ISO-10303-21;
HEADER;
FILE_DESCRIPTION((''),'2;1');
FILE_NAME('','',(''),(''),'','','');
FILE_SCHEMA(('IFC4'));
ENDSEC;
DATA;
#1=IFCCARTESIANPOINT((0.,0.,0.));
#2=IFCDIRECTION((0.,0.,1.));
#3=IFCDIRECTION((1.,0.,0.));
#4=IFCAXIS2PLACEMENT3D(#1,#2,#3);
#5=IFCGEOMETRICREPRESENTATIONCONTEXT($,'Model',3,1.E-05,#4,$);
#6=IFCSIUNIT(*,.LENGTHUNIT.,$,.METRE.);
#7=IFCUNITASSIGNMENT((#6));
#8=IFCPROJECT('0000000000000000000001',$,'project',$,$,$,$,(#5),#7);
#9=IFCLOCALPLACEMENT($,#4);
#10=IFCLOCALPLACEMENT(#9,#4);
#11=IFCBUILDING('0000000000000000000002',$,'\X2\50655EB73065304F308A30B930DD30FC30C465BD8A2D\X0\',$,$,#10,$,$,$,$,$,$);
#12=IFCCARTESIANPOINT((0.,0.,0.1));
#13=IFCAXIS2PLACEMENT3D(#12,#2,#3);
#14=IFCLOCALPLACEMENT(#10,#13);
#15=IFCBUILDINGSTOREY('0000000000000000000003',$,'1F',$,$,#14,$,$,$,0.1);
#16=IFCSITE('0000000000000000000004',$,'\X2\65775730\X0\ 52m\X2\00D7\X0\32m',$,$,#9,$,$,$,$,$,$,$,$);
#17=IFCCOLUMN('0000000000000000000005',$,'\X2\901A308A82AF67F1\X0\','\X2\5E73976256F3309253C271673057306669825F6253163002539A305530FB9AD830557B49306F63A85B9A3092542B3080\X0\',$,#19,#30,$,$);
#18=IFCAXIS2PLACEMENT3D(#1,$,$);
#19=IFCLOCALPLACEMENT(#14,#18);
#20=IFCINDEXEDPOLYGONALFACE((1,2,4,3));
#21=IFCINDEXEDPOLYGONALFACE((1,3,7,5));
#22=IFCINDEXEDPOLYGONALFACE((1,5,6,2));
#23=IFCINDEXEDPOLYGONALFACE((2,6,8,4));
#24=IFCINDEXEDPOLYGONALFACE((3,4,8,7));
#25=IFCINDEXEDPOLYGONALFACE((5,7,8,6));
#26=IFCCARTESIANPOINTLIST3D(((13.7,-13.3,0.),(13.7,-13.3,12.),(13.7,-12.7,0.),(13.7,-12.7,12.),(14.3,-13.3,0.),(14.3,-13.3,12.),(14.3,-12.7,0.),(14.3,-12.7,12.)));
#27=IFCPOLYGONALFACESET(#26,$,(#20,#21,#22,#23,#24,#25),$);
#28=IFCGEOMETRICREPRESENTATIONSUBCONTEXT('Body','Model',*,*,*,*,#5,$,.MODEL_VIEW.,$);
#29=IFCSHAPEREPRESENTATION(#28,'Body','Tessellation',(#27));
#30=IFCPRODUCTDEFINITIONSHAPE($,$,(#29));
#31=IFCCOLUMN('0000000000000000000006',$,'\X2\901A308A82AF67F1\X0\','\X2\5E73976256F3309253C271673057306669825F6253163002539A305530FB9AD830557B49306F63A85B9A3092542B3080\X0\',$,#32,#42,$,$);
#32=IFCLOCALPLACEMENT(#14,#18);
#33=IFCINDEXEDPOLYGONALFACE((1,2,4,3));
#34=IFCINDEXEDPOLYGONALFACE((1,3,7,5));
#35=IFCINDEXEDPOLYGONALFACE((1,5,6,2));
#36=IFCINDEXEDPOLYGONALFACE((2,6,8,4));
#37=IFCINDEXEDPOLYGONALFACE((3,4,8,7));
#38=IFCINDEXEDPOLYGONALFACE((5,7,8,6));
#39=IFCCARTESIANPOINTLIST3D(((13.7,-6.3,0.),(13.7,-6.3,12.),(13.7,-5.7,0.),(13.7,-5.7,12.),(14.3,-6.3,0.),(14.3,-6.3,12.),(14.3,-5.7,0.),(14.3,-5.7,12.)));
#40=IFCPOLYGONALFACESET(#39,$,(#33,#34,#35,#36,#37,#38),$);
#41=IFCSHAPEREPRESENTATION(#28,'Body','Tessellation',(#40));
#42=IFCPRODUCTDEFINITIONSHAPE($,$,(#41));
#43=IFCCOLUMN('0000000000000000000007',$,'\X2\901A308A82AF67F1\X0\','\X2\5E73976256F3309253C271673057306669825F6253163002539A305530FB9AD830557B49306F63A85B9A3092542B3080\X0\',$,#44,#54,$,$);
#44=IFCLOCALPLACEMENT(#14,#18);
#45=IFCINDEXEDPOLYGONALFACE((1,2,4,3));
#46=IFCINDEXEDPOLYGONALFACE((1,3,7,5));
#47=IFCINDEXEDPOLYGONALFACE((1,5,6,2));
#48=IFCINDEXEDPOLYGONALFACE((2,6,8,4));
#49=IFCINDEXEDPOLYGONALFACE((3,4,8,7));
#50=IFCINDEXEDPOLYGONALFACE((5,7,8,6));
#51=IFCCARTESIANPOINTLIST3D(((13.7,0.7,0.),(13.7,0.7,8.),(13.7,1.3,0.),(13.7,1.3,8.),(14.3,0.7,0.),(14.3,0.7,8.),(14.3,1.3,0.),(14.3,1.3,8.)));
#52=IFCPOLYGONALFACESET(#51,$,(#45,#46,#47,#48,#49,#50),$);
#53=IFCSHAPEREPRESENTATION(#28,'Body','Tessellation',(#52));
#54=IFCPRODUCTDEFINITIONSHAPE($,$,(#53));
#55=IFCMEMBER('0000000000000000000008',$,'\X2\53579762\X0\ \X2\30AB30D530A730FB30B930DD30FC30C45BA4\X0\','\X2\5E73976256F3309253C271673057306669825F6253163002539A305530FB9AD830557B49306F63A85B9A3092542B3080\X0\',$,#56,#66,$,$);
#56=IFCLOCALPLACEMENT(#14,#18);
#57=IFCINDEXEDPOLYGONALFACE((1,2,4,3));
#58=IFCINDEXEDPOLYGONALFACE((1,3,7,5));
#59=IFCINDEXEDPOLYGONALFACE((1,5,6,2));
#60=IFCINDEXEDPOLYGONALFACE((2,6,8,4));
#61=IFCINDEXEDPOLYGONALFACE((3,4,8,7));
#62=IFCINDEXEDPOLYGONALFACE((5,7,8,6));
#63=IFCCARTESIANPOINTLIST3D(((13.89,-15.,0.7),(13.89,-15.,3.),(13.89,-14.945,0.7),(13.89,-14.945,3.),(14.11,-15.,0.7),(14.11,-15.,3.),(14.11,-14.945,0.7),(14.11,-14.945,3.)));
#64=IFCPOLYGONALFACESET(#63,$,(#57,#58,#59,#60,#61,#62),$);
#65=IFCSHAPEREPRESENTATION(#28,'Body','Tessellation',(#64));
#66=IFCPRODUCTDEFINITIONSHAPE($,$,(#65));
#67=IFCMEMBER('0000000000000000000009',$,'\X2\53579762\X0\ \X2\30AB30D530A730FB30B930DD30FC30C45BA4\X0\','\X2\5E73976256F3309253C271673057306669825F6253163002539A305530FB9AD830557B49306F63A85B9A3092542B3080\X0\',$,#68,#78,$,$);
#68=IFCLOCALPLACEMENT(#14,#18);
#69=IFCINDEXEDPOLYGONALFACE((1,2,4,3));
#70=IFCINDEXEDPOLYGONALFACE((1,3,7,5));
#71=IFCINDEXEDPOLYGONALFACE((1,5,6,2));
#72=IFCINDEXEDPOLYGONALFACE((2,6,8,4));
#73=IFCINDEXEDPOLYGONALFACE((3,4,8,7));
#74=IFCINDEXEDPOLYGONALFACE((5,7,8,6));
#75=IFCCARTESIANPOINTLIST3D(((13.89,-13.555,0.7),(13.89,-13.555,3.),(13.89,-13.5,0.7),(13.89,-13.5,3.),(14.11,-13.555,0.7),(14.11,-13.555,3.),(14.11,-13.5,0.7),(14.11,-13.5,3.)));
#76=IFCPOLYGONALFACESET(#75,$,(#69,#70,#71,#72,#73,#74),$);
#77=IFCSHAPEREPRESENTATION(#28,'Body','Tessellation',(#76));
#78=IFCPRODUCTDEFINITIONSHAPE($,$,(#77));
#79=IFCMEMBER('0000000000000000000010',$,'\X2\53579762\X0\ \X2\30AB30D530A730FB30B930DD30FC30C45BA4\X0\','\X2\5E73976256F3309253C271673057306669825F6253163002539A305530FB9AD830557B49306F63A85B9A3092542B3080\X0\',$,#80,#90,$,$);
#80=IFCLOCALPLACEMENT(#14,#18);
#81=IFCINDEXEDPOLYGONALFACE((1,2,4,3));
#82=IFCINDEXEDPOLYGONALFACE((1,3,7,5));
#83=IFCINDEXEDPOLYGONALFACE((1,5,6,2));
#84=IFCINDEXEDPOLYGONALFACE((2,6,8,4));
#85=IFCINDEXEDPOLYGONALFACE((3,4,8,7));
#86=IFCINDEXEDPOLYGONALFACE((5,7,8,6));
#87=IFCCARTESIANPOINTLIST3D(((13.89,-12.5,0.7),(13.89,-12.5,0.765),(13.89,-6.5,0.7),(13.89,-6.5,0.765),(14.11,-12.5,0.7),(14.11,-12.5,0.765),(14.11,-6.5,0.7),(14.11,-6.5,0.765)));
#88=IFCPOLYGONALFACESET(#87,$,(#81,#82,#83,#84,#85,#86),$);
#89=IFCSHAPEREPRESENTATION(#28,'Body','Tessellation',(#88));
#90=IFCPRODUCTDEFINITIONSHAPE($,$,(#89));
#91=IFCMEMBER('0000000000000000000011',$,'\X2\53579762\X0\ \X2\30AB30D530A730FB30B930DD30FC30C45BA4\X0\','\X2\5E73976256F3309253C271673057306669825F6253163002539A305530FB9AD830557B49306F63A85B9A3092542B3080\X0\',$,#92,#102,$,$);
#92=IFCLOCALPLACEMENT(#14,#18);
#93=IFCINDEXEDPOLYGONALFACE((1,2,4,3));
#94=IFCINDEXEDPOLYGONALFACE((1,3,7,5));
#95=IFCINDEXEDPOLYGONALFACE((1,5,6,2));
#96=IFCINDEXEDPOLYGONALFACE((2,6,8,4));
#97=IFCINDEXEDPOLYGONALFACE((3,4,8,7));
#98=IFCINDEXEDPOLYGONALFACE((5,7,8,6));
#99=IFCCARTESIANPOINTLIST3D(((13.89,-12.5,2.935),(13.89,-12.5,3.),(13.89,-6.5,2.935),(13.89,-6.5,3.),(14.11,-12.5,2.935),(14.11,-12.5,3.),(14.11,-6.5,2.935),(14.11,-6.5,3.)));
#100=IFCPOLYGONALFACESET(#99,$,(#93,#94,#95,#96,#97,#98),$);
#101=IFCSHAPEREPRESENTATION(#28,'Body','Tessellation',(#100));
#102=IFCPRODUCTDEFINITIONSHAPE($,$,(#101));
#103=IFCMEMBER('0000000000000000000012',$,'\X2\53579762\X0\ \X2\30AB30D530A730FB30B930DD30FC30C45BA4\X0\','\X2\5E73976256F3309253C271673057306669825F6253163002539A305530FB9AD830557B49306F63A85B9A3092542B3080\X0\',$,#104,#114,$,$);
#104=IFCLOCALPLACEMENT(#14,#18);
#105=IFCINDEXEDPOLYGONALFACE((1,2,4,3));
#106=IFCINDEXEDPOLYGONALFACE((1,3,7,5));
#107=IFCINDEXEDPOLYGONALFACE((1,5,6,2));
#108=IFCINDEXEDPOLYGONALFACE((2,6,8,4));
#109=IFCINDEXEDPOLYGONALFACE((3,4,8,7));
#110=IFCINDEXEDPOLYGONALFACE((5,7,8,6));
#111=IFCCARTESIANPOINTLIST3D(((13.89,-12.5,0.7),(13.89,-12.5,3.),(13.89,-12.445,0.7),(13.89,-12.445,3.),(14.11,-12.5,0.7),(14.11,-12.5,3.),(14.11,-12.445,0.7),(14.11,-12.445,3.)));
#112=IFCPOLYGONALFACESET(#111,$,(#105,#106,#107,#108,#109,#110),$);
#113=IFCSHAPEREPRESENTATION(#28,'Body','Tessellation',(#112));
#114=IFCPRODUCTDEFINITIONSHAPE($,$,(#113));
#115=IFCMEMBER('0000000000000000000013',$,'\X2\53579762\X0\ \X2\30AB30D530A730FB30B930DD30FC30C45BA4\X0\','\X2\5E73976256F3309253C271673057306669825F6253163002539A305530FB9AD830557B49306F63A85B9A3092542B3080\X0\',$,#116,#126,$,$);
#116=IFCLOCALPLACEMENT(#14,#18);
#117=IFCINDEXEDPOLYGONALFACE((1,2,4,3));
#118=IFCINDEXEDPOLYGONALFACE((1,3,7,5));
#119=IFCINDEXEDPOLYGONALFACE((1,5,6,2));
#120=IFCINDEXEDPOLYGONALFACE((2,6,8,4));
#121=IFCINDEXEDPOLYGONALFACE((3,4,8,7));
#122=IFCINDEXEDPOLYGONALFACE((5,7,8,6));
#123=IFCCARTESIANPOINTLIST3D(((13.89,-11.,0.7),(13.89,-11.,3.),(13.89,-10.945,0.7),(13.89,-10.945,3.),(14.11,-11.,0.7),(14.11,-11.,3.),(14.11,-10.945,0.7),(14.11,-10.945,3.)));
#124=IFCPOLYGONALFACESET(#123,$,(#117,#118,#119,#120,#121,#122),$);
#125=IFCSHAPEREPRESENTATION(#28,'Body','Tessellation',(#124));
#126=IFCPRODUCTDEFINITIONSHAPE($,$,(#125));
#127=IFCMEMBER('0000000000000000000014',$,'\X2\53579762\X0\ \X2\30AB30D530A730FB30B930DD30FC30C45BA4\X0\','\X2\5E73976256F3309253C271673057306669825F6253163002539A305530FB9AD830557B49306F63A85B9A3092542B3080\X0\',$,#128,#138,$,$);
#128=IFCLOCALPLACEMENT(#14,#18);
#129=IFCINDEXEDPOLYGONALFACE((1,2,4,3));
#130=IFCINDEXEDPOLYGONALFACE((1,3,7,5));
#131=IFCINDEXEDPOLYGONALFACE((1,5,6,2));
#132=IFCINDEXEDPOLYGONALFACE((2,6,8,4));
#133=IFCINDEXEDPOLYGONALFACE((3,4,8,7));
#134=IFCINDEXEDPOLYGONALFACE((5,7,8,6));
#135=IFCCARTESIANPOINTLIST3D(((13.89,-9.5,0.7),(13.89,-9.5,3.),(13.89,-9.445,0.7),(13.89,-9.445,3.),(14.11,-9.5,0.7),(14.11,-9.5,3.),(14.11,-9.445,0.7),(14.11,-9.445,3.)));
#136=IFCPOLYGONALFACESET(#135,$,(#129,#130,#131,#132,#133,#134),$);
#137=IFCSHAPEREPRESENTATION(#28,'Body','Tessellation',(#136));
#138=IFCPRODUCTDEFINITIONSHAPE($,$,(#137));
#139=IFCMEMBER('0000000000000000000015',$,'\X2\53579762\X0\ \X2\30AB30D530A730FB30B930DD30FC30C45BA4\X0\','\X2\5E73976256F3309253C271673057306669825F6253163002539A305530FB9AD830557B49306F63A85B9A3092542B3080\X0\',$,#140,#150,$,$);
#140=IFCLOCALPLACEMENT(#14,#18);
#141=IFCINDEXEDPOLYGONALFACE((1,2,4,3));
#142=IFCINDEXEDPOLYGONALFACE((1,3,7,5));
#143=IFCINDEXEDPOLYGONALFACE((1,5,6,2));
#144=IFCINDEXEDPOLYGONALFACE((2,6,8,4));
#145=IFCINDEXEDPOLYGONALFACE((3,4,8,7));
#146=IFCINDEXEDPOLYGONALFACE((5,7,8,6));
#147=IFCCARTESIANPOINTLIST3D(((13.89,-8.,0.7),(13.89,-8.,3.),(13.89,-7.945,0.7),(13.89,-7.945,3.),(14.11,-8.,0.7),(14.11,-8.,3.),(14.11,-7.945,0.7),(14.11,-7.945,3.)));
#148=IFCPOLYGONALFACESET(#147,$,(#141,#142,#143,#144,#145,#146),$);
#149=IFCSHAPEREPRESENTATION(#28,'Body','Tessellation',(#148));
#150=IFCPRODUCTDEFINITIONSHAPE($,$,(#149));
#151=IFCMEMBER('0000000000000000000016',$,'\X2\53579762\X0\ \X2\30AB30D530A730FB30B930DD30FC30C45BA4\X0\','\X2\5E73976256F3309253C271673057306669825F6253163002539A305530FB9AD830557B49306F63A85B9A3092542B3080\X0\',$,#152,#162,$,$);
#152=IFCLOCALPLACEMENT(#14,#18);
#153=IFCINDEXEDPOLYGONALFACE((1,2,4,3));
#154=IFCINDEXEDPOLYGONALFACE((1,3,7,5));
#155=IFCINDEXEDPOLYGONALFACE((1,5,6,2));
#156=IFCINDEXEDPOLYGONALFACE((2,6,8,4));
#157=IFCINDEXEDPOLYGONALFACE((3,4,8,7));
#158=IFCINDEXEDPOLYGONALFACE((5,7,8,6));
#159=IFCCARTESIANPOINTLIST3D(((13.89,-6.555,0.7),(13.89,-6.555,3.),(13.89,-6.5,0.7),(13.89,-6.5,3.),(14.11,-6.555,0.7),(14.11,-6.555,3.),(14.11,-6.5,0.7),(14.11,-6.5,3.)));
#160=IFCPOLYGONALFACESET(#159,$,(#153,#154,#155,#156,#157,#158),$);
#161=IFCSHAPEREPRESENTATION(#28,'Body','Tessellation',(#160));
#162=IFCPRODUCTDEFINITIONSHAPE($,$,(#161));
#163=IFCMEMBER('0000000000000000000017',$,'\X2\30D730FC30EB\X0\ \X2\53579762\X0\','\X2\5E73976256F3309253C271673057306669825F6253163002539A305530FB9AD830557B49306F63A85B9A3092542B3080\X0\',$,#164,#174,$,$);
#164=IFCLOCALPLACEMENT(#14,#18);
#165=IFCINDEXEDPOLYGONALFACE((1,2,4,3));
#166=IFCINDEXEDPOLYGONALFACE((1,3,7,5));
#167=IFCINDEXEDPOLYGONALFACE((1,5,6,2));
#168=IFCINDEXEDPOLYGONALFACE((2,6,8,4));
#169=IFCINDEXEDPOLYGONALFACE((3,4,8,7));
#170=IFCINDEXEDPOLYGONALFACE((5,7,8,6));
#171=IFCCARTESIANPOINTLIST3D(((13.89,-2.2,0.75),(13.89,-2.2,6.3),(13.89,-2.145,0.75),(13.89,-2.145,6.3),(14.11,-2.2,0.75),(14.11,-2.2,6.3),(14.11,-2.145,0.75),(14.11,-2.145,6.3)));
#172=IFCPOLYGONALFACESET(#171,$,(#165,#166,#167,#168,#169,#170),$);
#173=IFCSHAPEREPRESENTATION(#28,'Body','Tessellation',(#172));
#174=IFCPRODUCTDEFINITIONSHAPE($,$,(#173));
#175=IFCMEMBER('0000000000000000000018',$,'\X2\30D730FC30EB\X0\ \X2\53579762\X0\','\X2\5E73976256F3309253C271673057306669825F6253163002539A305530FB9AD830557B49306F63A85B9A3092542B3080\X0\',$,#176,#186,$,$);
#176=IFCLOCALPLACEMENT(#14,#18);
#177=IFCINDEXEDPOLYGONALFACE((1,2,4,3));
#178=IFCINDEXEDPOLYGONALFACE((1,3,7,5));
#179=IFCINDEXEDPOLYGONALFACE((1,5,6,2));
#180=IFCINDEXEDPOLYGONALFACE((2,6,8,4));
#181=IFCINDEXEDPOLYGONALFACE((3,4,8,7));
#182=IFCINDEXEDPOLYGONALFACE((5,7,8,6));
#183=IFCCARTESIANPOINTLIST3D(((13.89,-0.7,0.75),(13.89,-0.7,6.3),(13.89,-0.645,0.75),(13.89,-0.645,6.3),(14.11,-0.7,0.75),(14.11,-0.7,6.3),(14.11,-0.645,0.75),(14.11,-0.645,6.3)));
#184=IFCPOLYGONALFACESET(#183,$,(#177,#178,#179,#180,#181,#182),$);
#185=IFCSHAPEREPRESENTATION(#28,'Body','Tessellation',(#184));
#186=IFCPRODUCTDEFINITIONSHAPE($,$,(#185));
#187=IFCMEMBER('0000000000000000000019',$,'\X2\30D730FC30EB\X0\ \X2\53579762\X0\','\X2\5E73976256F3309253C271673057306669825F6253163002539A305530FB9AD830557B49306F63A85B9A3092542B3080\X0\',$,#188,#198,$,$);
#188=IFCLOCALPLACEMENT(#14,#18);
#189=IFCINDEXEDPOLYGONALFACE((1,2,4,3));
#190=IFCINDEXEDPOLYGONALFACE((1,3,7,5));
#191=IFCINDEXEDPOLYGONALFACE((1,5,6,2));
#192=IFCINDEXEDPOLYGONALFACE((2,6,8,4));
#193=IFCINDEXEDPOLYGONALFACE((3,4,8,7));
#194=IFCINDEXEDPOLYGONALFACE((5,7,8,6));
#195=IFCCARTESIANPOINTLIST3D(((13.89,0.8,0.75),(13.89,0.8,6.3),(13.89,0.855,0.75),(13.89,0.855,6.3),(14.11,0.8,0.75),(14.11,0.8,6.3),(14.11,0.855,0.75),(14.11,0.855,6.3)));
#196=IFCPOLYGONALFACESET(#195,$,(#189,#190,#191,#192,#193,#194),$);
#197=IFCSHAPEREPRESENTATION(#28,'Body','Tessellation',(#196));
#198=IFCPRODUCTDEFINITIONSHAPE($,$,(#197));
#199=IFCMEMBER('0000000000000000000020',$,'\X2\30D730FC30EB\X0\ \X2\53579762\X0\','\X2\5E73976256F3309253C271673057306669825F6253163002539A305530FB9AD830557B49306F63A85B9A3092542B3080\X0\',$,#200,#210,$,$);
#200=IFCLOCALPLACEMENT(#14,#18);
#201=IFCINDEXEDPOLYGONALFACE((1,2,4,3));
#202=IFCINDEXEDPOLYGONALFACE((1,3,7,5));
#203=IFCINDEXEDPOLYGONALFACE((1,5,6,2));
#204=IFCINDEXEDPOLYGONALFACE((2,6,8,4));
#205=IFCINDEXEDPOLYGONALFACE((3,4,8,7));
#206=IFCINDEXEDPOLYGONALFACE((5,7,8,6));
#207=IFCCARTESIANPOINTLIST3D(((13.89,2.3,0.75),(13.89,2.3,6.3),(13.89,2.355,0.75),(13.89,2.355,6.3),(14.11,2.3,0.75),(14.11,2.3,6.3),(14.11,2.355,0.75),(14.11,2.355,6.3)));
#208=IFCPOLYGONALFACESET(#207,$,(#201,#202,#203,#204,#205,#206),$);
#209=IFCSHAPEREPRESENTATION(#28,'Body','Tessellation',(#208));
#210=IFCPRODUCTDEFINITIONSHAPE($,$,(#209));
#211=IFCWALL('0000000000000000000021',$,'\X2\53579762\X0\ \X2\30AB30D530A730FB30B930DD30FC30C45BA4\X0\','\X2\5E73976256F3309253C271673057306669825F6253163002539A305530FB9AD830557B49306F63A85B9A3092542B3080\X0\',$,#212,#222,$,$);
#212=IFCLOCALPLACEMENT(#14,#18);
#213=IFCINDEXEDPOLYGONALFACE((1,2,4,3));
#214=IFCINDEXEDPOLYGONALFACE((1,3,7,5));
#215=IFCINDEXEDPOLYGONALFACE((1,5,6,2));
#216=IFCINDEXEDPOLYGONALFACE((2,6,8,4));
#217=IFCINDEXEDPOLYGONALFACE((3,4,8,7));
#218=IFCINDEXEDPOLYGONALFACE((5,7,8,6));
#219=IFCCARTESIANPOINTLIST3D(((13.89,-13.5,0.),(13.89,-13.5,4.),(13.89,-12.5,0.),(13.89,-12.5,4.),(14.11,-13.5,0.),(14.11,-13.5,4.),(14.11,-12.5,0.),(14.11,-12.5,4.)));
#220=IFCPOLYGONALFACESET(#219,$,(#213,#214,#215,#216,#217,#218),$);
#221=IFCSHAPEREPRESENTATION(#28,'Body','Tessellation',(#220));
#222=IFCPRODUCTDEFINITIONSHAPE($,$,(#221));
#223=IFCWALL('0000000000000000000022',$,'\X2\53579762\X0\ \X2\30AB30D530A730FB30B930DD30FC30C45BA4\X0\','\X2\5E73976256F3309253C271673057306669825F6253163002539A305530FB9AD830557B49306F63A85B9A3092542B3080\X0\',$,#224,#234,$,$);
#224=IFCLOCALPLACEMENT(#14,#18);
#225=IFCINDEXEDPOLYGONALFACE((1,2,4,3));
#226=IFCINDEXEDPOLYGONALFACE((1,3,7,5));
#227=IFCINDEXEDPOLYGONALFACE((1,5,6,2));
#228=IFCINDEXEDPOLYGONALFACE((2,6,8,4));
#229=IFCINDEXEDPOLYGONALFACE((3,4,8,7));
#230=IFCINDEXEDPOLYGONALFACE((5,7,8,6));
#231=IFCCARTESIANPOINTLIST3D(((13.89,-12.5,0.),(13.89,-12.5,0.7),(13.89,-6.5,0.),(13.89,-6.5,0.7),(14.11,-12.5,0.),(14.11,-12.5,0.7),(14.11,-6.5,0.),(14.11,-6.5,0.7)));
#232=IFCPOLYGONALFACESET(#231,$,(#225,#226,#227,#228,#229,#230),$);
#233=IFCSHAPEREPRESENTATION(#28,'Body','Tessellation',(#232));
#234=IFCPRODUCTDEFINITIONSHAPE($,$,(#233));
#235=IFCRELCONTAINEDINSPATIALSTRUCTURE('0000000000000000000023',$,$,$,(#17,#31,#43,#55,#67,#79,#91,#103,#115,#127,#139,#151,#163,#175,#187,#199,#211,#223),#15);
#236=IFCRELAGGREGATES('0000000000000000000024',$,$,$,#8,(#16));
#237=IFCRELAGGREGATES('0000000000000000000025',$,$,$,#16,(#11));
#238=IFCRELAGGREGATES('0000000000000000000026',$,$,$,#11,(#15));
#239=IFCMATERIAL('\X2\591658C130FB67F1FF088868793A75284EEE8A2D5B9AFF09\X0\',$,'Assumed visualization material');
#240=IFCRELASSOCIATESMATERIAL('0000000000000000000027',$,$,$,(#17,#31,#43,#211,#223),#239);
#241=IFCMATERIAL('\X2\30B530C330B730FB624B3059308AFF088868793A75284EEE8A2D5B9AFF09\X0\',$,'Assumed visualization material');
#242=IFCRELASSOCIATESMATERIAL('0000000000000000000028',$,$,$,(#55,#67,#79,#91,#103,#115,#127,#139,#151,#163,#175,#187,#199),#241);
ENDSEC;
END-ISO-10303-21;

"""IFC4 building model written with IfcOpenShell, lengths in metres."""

from ifc_helpers import new_model, si_unit, frame, origin_with_axes, place, context, subcontext, project, spatial, rectangle, extrude, material, element, save


model = new_model("IFC4")

# Units and contexts
model_context = context("Model", 3, precision=1e-05, world=origin_with_axes())
body_context = subcontext(model_context, "Body", "Model", "MODEL_VIEW")
ifc_project = project(units=[si_unit("LENGTHUNIT", "METRE")], contexts=[model_context])

# Site, building, storey
site_placement = place(None, origin_with_axes())
site = spatial("IfcSite", under=ifc_project, at=site_placement, Name="敷地 52m×32m")
building_placement = place(site_placement, origin_with_axes())
building = spatial("IfcBuilding", under=site, at=building_placement, Name="健康づくりスポーツ施設")
storey_placement = place(building_placement, frame((0.0, 0.0, 0.1), z_axis=(0.0, 0.0, 1.0), x_axis=(1.0, 0.0, 0.0)))
storey = spatial("IfcBuildingStorey", under=building, at=storey_placement, Name="1F", Elevation=0.1)

# Columns
ifc_material_1 = material(Name="外壁・柱（表示用仮設定）", Category="Assumed visualization material")
column_1_placement = place(storey_placement, frame((14.0, -13.0, 0.0), z_axis=(0.0, 0.0, 1.0), x_axis=(1.0, 0.0, 0.0)))
element("IfcColumn", 1, at=column_1_placement, inside=storey, material=ifc_material_1, Name="通り芯柱", Description="平面図を参照して概形化。厚さ・高さ等は推定を含む", context=body_context, shape_type="SweptSolid", body=[
    extrude(rectangle(XDim=0.6, YDim=0.6), origin_with_axes(), (0.0, 0.0, 1.0), 12.0),
])
column_2_placement = place(storey_placement, frame((14.0, -6.0, 0.0), z_axis=(0.0, 0.0, 1.0), x_axis=(1.0, 0.0, 0.0)))
element("IfcColumn", 2, at=column_2_placement, inside=storey, material=ifc_material_1, Name="通り芯柱", Description="平面図を参照して概形化。厚さ・高さ等は推定を含む", context=body_context, shape_type="SweptSolid", body=[
    extrude(rectangle(XDim=0.6, YDim=0.6), origin_with_axes(), (0.0, 0.0, 1.0), 12.0),
])
column_3_placement = place(storey_placement, frame((14.0, 1.0, 0.0), z_axis=(0.0, 0.0, 1.0), x_axis=(1.0, 0.0, 0.0)))
element("IfcColumn", 3, at=column_3_placement, inside=storey, material=ifc_material_1, Name="通り芯柱", Description="平面図を参照して概形化。厚さ・高さ等は推定を含む", context=body_context, shape_type="SweptSolid", body=[
    extrude(rectangle(XDim=0.6, YDim=0.6), origin_with_axes(), (0.0, 0.0, 1.0), 8.0),
])

# Members
ifc_material_2 = material(Name="サッシ・手すり（表示用仮設定）", Category="Assumed visualization material")
for number, where, z_axis, x_axis, name in (
    (4, (14.0, -14.9725, 0.7), (0.0, 0.0, 1.0), (1.0, 0.0, 0.0), "南面 カフェ・スポーツ室"),
    (5, (14.0, -13.5275, 0.7), (0.0, 0.0, 1.0), (1.0, 0.0, 0.0), "南面 カフェ・スポーツ室"),
):
    element("IfcMember", number, at=place(storey_placement, frame(where, z_axis=z_axis, x_axis=x_axis)), inside=storey, material=ifc_material_2, Name=name, Description="平面図を参照して概形化。厚さ・高さ等は推定を含む", context=body_context, shape_type="SweptSolid", body=[
        extrude(rectangle(XDim=0.22, YDim=0.055), origin_with_axes(), (0.0, 0.0, 1.0), 2.3),
    ])
member_1_placement = place(storey_placement, frame((14.0, -9.5, 0.7), z_axis=(0.0, 0.0, 1.0), x_axis=(1.0, 0.0, 0.0)))
element("IfcMember", 6, at=member_1_placement, inside=storey, material=ifc_material_2, Name="南面 カフェ・スポーツ室", Description="平面図を参照して概形化。厚さ・高さ等は推定を含む", context=body_context, shape_type="SweptSolid", body=[
    extrude(rectangle(XDim=0.22, YDim=6.0), origin_with_axes(), (0.0, 0.0, 1.0), 0.065),
])
member_2_placement = place(storey_placement, frame((14.0, -9.5, 2.935), z_axis=(0.0, 0.0, 1.0), x_axis=(1.0, 0.0, 0.0)))
element("IfcMember", 7, at=member_2_placement, inside=storey, material=ifc_material_2, Name="南面 カフェ・スポーツ室", Description="平面図を参照して概形化。厚さ・高さ等は推定を含む", context=body_context, shape_type="SweptSolid", body=[
    extrude(rectangle(XDim=0.22, YDim=6.0), origin_with_axes(), (0.0, 0.0, 1.0), 0.065),
])
for number, where, z_axis, x_axis, name in (
    (8, (14.0, -12.4725, 0.7), (0.0, 0.0, 1.0), (1.0, 0.0, 0.0), "南面 カフェ・スポーツ室"),
    (9, (14.0, -10.9725, 0.7), (0.0, 0.0, 1.0), (1.0, 0.0, 0.0), "南面 カフェ・スポーツ室"),
    (10, (14.0, -9.4725, 0.7), (0.0, 0.0, 1.0), (1.0, 0.0, 0.0), "南面 カフェ・スポーツ室"),
    (11, (14.0, -7.9725, 0.7), (0.0, 0.0, 1.0), (1.0, 0.0, 0.0), "南面 カフェ・スポーツ室"),
    (12, (14.0, -6.5275, 0.7), (0.0, 0.0, 1.0), (1.0, 0.0, 0.0), "南面 カフェ・スポーツ室"),
):
    element("IfcMember", number, at=place(storey_placement, frame(where, z_axis=z_axis, x_axis=x_axis)), inside=storey, material=ifc_material_2, Name=name, Description="平面図を参照して概形化。厚さ・高さ等は推定を含む", context=body_context, shape_type="SweptSolid", body=[
        extrude(rectangle(XDim=0.22, YDim=0.055), origin_with_axes(), (0.0, 0.0, 1.0), 2.3),
    ])
for number, where, z_axis, x_axis, name in (
    (13, (14.0, -2.1725, 0.75), (0.0, 0.0, 1.0), (1.0, 0.0, 0.0), "プール 南面"),
    (14, (14.0, -0.6725, 0.75), (0.0, 0.0, 1.0), (1.0, 0.0, 0.0), "プール 南面"),
    (15, (14.0, 0.8275, 0.75), (0.0, 0.0, 1.0), (1.0, 0.0, 0.0), "プール 南面"),
    (16, (14.0, 2.3275, 0.75), (0.0, 0.0, 1.0), (1.0, 0.0, 0.0), "プール 南面"),
):
    element("IfcMember", number, at=place(storey_placement, frame(where, z_axis=z_axis, x_axis=x_axis)), inside=storey, material=ifc_material_2, Name=name, Description="平面図を参照して概形化。厚さ・高さ等は推定を含む", context=body_context, shape_type="SweptSolid", body=[
        extrude(rectangle(XDim=0.22, YDim=0.055), origin_with_axes(), (0.0, 0.0, 1.0), 5.55),
    ])

# Walls
wall_1_placement = place(storey_placement, frame((14.0, -13.0, 0.0), z_axis=(0.0, 0.0, 1.0), x_axis=(1.0, 0.0, 0.0)))
element("IfcWall", 17, at=wall_1_placement, inside=storey, material=ifc_material_1, Name="南面 カフェ・スポーツ室", Description="平面図を参照して概形化。厚さ・高さ等は推定を含む", context=body_context, shape_type="SweptSolid", body=[
    extrude(rectangle(XDim=0.22, YDim=1.0), origin_with_axes(), (0.0, 0.0, 1.0), 4.0),
])
wall_2_placement = place(storey_placement, frame((14.0, -9.5, 0.0), z_axis=(0.0, 0.0, 1.0), x_axis=(1.0, 0.0, 0.0)))
element("IfcWall", 18, at=wall_2_placement, inside=storey, material=ifc_material_1, Name="南面 カフェ・スポーツ室", Description="平面図を参照して概形化。厚さ・高さ等は推定を含む", context=body_context, shape_type="SweptSolid", body=[
    extrude(rectangle(XDim=0.22, YDim=6.0), origin_with_axes(), (0.0, 0.0, 1.0), 0.7),
])

save(model, "model.ifc")
